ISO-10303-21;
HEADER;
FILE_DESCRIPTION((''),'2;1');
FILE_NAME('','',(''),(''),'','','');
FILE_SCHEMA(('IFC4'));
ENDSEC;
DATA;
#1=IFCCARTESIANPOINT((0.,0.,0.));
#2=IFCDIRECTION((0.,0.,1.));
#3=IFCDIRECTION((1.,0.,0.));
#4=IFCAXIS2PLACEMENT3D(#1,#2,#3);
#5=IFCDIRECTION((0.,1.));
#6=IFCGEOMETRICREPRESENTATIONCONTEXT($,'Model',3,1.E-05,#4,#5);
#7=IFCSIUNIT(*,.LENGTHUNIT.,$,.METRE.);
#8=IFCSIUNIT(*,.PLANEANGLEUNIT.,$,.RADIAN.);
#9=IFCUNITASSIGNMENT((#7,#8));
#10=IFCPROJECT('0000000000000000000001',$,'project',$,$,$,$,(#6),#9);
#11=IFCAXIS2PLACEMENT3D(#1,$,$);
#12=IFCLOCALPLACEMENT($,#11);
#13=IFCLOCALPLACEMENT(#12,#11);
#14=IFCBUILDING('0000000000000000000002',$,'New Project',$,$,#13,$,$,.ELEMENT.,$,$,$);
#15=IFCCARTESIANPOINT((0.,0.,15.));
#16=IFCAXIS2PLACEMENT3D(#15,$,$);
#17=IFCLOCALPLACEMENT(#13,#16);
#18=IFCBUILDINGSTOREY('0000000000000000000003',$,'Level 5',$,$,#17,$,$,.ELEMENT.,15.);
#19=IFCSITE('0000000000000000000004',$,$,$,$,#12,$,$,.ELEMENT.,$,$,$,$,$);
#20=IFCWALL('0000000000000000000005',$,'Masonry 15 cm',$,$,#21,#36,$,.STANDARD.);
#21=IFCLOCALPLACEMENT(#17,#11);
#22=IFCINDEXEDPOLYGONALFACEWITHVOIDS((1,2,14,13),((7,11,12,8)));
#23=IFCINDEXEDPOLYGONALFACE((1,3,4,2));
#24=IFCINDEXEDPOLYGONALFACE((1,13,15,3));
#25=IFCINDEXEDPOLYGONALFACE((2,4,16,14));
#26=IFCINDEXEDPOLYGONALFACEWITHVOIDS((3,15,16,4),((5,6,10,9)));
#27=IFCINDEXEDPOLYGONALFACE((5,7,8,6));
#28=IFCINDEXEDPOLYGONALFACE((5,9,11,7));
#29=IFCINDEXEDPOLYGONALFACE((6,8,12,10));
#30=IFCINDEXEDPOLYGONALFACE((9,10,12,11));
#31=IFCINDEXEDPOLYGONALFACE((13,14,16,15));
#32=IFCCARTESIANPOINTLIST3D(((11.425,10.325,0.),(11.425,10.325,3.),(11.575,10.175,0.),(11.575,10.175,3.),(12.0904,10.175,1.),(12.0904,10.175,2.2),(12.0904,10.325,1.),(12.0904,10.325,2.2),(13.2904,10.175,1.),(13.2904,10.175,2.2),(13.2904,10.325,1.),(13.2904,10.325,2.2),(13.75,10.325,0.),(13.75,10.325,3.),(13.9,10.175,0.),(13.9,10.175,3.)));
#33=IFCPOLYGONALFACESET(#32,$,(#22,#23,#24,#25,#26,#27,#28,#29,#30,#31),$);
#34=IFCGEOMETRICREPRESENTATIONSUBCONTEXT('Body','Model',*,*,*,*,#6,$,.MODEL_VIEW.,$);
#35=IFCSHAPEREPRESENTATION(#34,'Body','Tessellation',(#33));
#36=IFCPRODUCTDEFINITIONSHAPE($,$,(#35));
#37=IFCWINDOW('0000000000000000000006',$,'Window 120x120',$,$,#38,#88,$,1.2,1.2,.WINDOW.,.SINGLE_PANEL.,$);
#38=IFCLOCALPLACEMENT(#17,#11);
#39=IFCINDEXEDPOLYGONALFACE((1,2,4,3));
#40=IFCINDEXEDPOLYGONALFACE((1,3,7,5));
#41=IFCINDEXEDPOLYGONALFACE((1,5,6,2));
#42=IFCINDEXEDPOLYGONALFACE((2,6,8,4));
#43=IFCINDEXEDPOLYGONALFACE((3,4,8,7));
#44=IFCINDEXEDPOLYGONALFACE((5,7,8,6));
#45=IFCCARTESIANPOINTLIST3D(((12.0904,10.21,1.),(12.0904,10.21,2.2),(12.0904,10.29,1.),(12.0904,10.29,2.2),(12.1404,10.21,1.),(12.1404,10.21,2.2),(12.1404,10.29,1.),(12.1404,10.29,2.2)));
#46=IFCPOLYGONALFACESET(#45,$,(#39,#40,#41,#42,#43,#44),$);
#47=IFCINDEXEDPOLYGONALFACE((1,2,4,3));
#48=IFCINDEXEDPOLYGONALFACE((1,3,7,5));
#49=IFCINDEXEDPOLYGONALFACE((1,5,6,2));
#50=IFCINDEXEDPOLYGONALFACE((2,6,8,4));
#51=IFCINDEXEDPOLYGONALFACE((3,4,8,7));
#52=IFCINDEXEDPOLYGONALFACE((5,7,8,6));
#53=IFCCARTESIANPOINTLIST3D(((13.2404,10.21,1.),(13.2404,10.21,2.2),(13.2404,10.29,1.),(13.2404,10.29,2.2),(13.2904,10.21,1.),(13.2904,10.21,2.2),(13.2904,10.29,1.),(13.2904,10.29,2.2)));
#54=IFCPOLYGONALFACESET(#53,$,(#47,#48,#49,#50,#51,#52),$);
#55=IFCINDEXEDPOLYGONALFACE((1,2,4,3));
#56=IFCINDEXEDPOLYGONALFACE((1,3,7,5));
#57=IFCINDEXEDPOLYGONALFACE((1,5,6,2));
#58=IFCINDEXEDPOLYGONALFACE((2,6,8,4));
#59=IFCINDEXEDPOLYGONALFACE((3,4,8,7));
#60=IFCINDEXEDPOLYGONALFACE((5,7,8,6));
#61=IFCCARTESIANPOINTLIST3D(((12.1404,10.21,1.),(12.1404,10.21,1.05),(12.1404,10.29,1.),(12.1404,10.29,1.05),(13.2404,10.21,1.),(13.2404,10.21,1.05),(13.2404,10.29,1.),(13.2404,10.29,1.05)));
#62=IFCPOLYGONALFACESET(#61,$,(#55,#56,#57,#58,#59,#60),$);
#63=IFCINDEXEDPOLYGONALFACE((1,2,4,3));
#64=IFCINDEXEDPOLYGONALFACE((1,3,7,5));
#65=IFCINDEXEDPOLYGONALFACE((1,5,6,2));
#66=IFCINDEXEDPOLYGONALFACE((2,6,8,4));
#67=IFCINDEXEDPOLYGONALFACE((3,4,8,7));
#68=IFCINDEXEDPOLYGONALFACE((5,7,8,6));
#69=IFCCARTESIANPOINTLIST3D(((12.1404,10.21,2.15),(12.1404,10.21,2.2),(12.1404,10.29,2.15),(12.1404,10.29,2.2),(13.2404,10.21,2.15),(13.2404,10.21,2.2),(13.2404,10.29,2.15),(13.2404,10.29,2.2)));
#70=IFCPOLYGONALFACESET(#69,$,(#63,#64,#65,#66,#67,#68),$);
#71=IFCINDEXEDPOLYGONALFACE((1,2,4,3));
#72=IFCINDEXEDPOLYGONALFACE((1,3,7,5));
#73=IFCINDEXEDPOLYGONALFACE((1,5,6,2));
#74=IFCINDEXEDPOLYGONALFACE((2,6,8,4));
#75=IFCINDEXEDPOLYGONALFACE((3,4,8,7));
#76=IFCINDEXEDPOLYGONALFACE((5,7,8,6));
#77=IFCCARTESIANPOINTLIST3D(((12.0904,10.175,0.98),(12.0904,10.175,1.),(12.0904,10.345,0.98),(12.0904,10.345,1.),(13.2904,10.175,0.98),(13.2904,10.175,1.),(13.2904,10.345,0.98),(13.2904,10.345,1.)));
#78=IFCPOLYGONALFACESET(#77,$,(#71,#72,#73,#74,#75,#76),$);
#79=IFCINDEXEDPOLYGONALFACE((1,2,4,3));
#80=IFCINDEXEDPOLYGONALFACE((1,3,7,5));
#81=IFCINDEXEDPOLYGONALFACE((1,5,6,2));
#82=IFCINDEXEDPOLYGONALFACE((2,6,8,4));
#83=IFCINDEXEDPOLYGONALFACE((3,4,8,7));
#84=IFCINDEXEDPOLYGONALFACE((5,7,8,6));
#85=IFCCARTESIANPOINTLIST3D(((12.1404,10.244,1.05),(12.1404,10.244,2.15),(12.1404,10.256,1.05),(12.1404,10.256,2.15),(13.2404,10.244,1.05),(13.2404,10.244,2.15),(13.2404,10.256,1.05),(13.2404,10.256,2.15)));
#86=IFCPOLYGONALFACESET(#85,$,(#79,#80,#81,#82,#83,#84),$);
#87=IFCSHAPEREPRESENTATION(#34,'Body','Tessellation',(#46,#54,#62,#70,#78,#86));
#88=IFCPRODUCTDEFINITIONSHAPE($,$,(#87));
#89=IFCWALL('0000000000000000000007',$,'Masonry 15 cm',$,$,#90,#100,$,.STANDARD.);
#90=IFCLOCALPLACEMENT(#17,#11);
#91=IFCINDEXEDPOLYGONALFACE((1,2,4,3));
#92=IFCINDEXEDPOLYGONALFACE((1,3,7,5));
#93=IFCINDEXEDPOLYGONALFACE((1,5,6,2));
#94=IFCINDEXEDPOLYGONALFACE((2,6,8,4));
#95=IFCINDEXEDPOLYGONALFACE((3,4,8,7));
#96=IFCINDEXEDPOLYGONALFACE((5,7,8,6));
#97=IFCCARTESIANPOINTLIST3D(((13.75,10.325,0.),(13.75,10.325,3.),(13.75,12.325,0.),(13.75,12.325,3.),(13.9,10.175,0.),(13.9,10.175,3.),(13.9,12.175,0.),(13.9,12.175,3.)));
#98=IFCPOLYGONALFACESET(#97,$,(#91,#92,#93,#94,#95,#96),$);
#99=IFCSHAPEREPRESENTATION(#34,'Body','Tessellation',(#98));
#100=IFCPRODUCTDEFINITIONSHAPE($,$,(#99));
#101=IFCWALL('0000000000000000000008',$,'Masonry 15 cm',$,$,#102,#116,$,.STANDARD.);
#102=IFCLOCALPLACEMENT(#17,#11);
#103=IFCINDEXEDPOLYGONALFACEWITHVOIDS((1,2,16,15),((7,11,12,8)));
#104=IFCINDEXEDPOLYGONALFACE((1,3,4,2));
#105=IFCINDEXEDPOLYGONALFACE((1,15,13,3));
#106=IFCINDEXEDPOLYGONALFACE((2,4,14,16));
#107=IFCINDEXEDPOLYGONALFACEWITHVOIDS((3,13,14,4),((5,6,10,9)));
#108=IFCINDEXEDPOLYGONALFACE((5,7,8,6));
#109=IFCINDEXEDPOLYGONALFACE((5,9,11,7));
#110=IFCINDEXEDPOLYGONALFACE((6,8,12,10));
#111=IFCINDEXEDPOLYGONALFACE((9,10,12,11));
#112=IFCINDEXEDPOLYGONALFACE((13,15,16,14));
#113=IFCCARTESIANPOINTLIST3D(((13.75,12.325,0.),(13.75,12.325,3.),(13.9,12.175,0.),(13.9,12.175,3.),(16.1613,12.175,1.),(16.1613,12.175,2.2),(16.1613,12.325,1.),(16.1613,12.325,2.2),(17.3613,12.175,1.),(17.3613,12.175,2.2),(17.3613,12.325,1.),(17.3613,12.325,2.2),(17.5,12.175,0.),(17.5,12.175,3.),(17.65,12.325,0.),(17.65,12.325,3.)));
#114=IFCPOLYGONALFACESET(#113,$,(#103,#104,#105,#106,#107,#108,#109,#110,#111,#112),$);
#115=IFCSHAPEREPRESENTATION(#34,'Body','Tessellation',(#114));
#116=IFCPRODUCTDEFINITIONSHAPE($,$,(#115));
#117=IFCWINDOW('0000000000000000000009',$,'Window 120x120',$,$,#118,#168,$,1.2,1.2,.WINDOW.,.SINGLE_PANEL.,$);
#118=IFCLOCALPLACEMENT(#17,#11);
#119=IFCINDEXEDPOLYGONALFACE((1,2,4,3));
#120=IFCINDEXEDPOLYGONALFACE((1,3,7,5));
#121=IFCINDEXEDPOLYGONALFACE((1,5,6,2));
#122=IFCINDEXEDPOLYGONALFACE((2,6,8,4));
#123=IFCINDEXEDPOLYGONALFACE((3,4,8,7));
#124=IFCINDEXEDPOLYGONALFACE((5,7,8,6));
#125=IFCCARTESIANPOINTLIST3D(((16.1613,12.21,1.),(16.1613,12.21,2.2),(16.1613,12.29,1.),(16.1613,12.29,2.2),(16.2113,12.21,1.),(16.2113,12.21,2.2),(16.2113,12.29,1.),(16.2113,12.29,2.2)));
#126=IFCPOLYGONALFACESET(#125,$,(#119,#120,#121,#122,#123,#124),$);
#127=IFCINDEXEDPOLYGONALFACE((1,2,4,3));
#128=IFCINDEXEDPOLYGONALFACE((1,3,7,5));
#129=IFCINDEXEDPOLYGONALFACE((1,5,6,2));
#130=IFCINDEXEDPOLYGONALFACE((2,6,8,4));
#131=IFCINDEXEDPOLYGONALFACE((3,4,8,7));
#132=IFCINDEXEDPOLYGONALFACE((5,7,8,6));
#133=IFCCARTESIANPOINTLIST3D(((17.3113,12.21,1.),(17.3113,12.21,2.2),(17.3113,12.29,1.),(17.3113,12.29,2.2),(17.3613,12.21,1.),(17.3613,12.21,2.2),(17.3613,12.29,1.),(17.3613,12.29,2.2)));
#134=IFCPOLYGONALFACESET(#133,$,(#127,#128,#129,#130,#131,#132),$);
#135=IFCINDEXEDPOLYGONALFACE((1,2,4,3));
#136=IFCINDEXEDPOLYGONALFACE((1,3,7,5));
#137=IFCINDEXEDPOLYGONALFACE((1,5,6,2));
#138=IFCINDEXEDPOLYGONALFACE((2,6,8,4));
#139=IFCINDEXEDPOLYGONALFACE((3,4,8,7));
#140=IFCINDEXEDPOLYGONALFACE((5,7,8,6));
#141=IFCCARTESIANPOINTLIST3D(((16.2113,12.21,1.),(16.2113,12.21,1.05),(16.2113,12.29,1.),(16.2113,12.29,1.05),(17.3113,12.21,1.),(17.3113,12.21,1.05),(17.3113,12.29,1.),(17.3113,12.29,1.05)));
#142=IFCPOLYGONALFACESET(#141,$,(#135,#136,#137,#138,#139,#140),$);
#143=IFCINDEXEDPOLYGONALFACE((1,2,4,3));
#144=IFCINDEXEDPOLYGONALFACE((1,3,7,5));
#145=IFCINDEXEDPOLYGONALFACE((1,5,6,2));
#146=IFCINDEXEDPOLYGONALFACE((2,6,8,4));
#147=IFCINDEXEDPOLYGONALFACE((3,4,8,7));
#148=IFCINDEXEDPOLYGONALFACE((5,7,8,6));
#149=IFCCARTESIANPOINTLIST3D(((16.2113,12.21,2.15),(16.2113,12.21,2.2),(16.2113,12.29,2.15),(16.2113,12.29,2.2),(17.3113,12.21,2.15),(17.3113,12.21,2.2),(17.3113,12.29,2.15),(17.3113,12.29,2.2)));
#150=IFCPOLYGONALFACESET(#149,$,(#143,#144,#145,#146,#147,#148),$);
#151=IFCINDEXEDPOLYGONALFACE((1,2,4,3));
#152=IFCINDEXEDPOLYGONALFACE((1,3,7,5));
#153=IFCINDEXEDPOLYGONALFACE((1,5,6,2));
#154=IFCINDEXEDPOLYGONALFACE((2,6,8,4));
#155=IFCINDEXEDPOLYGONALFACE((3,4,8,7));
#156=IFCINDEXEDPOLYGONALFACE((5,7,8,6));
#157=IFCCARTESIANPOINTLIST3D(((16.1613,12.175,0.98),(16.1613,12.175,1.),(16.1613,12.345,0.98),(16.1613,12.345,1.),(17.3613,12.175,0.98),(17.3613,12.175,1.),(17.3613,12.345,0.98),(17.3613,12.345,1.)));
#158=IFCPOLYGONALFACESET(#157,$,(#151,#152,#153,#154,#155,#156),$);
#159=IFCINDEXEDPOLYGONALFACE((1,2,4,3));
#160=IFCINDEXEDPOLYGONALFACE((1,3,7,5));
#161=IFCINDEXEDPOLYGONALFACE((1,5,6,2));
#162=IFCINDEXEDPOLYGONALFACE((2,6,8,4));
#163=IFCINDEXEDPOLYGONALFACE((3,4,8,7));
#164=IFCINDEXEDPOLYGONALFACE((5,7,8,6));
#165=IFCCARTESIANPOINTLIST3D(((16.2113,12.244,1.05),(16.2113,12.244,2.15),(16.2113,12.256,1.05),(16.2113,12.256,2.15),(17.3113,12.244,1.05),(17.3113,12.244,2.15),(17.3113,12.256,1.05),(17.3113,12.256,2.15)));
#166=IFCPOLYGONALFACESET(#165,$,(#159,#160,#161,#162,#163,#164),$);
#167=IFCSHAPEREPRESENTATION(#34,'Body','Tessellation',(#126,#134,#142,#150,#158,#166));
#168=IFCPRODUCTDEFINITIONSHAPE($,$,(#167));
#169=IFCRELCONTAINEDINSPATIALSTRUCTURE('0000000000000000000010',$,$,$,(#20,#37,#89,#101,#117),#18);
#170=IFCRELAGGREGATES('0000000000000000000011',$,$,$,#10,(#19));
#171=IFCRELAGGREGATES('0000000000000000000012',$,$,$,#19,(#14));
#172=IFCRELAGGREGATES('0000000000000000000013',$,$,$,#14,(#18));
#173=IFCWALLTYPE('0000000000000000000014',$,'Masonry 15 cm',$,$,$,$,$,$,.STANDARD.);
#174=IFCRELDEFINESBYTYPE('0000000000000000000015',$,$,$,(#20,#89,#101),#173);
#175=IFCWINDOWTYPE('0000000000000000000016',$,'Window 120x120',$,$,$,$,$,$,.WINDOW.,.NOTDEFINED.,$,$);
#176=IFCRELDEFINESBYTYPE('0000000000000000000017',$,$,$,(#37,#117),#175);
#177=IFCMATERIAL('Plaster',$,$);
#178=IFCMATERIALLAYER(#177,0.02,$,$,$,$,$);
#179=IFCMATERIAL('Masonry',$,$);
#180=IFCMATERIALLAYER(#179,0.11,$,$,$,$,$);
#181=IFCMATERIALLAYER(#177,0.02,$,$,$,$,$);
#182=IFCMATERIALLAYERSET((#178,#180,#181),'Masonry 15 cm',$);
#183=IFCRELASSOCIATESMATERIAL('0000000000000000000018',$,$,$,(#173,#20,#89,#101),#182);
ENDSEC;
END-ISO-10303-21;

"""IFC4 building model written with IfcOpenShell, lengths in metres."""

from ifc_helpers import new_model, si_unit, direction, frame, frame_2d, origin, origin_with_axes, place, context, subcontext, project, spatial, polyline, rectangle, outline, extrude, material, layer, layer_set, layer_usage, type_object, element, fill, save


model = new_model("IFC4")

# Units and contexts
model_context = context("Model", 3, precision=1e-05, world=origin_with_axes(), true_north=direction((0.0, 1.0)))
body_context = subcontext(model_context, "Body", "Model", "MODEL_VIEW")
ifc_project = project(units=[si_unit("LENGTHUNIT", "METRE"), si_unit("PLANEANGLEUNIT", "RADIAN")], contexts=[model_context])

# Site, building, storey
site_placement = place(None, origin())
site = spatial("IfcSite", under=ifc_project, at=site_placement, CompositionType="ELEMENT")
building_placement = place(site_placement, origin())
building = spatial("IfcBuilding", under=site, at=building_placement, Name="New Project", CompositionType="ELEMENT")
storey_placement = place(building_placement, frame((0.0, 0.0, 15.0)))
storey = spatial("IfcBuildingStorey", under=building, at=storey_placement, Name="Level 5", CompositionType="ELEMENT", Elevation=15.0)

# Shared definitions
ifc_material_1 = material(Name="Plaster")
ifc_layer_1 = layer(ifc_material_1, 0.02)
ifc_material_2 = material(Name="Masonry")
ifc_layer_2 = layer(ifc_material_2, 0.11)
ifc_layer_3 = layer(ifc_material_1, 0.02)
ifc_layer_set_1 = layer_set([ifc_layer_1, ifc_layer_2, ifc_layer_3], Name="Masonry 15 cm")
ifc_layer_usage_1 = layer_usage(ifc_layer_set_1, "AXIS2", "NEGATIVE", 0.075)
wall_type_1 = type_object("IfcWallType", Name="Masonry 15 cm", PredefinedType="STANDARD", material=ifc_layer_set_1)
window_type = type_object("IfcWindowType", Name="Window 120x120", PartitioningType="NOTDEFINED", PredefinedType="WINDOW")

# Wall, opening, window
wall_1_placement = place(storey_placement, frame((11.5, 10.25, 0.0)))
wall_1 = element("IfcWall", 1, at=wall_1_placement, inside=storey, type_object=wall_type_1, material=ifc_layer_usage_1, Name="Masonry 15 cm", PredefinedType="STANDARD", context=body_context, shape_type="SweptSolid", body=[
    extrude(outline(polyline([(0.075, -0.075), (2.4, -0.075), (2.25, 0.075), (-0.075, 0.075), (0.075, -0.075)])), origin(), (0.0, 0.0, 1.0), 3.0),
])
opening_1_placement = place(wall_1_placement, frame((0.5904, 0.0, 1.0)))
opening_1 = element("IfcOpeningElement", 2, at=opening_1_placement, cuts=wall_1, PredefinedType="OPENING", context=body_context, shape_type="SweptSolid", body=[
    extrude(rectangle(XDim=1.2, YDim=0.25, at=frame_2d((0.6, 0.0))), origin(), (0.0, 0.0, 1.0), 1.2),
])
window_1_placement = place(opening_1_placement, origin())
window_1 = element("IfcWindow", 3, at=window_1_placement, inside=storey, type_object=window_type, Name="Window 120x120", OverallHeight=1.2, OverallWidth=1.2, PartitioningType="SINGLE_PANEL", PredefinedType="WINDOW", context=body_context, shape_type="SweptSolid", body=[
    extrude(outline(polyline([(0.0, -0.04), (0.05, -0.04), (0.05, 0.04), (0.0, 0.04), (0.0, -0.04)])), origin(), (0.0, 0.0, 1.0), 1.2),
    extrude(outline(polyline([(1.15, -0.04), (1.2, -0.04), (1.2, 0.04), (1.15, 0.04), (1.15, -0.04)])), origin(), (0.0, 0.0, 1.0), 1.2),
    extrude(outline(polyline([(0.05, -0.04), (1.15, -0.04), (1.15, 0.04), (0.05, 0.04), (0.05, -0.04)])), origin(), (0.0, 0.0, 1.0), 0.05),
    extrude(outline(polyline([(0.05, -0.04), (1.15, -0.04), (1.15, 0.04), (0.05, 0.04), (0.05, -0.04)])), frame((0.0, 0.0, 1.15)), (0.0, 0.0, 1.0), 0.05),
    extrude(outline(polyline([(0.0, -0.075), (1.2, -0.075), (1.2, 0.095), (0.0, 0.095), (0.0, -0.075)])), frame((0.0, 0.0, -0.02)), (0.0, 0.0, 1.0), 0.02),
    extrude(outline(polyline([(0.05, -0.006), (1.15, -0.006), (1.15, 0.006), (0.05, 0.006), (0.05, -0.006)])), frame((0.0, 0.0, 0.05)), (0.0, 0.0, 1.0), 1.1),
])
fill(opening_1, window_1)

# Wall
wall_2_placement = place(storey_placement, frame((13.825, 10.25, 0.0), z_axis=(0.0, 0.0, 1.0), x_axis=(0.0, 1.0, 0.0)))
element("IfcWall", 4, at=wall_2_placement, inside=storey, type_object=wall_type_1, material=ifc_layer_usage_1, Name="Masonry 15 cm", PredefinedType="STANDARD", context=body_context, shape_type="SweptSolid", body=[
    extrude(outline(polyline([(-0.075, -0.075), (1.925, -0.075), (2.075, 0.075), (0.075, 0.075), (-0.075, -0.075)])), origin(), (0.0, 0.0, 1.0), 3.0),
])

# Wall, opening, window
wall_3_placement = place(storey_placement, frame((13.825, 12.25, 0.0)))
wall_3 = element("IfcWall", 5, at=wall_3_placement, inside=storey, type_object=wall_type_1, material=ifc_layer_usage_1, Name="Masonry 15 cm", PredefinedType="STANDARD", context=body_context, shape_type="SweptSolid", body=[
    extrude(outline(polyline([(0.075, -0.075), (3.675, -0.075), (3.825, 0.075), (-0.075, 0.075), (0.075, -0.075)])), origin(), (0.0, 0.0, 1.0), 3.0),
])
opening_2_placement = place(wall_3_placement, frame((2.3363, 0.0, 1.0)))
opening_2 = element("IfcOpeningElement", 6, at=opening_2_placement, cuts=wall_3, PredefinedType="OPENING", context=body_context, shape_type="SweptSolid", body=[
    extrude(rectangle(XDim=1.2, YDim=0.25, at=frame_2d((0.6, 0.0))), origin(), (0.0, 0.0, 1.0), 1.2),
])
window_2_placement = place(opening_2_placement, origin())
window_2 = element("IfcWindow", 7, at=window_2_placement, inside=storey, type_object=window_type, Name="Window 120x120", OverallHeight=1.2, OverallWidth=1.2, PartitioningType="SINGLE_PANEL", PredefinedType="WINDOW", context=body_context, shape_type="SweptSolid", body=[
    extrude(outline(polyline([(0.0, -0.04), (0.05, -0.04), (0.05, 0.04), (0.0, 0.04), (0.0, -0.04)])), origin(), (0.0, 0.0, 1.0), 1.2),
    extrude(outline(polyline([(1.15, -0.04), (1.2, -0.04), (1.2, 0.04), (1.15, 0.04), (1.15, -0.04)])), origin(), (0.0, 0.0, 1.0), 1.2),
    extrude(outline(polyline([(0.05, -0.04), (1.15, -0.04), (1.15, 0.04), (0.05, 0.04), (0.05, -0.04)])), origin(), (0.0, 0.0, 1.0), 0.05),
    extrude(outline(polyline([(0.05, -0.04), (1.15, -0.04), (1.15, 0.04), (0.05, 0.04), (0.05, -0.04)])), frame((0.0, 0.0, 1.15)), (0.0, 0.0, 1.0), 0.05),
    extrude(outline(polyline([(0.0, -0.075), (1.2, -0.075), (1.2, 0.095), (0.0, 0.095), (0.0, -0.075)])), frame((0.0, 0.0, -0.02)), (0.0, 0.0, 1.0), 0.02),
    extrude(outline(polyline([(0.05, -0.006), (1.15, -0.006), (1.15, 0.006), (0.05, 0.006), (0.05, -0.006)])), frame((0.0, 0.0, 0.05)), (0.0, 0.0, 1.0), 1.1),
])
fill(opening_2, window_2)

save(model, "model.ifc")
